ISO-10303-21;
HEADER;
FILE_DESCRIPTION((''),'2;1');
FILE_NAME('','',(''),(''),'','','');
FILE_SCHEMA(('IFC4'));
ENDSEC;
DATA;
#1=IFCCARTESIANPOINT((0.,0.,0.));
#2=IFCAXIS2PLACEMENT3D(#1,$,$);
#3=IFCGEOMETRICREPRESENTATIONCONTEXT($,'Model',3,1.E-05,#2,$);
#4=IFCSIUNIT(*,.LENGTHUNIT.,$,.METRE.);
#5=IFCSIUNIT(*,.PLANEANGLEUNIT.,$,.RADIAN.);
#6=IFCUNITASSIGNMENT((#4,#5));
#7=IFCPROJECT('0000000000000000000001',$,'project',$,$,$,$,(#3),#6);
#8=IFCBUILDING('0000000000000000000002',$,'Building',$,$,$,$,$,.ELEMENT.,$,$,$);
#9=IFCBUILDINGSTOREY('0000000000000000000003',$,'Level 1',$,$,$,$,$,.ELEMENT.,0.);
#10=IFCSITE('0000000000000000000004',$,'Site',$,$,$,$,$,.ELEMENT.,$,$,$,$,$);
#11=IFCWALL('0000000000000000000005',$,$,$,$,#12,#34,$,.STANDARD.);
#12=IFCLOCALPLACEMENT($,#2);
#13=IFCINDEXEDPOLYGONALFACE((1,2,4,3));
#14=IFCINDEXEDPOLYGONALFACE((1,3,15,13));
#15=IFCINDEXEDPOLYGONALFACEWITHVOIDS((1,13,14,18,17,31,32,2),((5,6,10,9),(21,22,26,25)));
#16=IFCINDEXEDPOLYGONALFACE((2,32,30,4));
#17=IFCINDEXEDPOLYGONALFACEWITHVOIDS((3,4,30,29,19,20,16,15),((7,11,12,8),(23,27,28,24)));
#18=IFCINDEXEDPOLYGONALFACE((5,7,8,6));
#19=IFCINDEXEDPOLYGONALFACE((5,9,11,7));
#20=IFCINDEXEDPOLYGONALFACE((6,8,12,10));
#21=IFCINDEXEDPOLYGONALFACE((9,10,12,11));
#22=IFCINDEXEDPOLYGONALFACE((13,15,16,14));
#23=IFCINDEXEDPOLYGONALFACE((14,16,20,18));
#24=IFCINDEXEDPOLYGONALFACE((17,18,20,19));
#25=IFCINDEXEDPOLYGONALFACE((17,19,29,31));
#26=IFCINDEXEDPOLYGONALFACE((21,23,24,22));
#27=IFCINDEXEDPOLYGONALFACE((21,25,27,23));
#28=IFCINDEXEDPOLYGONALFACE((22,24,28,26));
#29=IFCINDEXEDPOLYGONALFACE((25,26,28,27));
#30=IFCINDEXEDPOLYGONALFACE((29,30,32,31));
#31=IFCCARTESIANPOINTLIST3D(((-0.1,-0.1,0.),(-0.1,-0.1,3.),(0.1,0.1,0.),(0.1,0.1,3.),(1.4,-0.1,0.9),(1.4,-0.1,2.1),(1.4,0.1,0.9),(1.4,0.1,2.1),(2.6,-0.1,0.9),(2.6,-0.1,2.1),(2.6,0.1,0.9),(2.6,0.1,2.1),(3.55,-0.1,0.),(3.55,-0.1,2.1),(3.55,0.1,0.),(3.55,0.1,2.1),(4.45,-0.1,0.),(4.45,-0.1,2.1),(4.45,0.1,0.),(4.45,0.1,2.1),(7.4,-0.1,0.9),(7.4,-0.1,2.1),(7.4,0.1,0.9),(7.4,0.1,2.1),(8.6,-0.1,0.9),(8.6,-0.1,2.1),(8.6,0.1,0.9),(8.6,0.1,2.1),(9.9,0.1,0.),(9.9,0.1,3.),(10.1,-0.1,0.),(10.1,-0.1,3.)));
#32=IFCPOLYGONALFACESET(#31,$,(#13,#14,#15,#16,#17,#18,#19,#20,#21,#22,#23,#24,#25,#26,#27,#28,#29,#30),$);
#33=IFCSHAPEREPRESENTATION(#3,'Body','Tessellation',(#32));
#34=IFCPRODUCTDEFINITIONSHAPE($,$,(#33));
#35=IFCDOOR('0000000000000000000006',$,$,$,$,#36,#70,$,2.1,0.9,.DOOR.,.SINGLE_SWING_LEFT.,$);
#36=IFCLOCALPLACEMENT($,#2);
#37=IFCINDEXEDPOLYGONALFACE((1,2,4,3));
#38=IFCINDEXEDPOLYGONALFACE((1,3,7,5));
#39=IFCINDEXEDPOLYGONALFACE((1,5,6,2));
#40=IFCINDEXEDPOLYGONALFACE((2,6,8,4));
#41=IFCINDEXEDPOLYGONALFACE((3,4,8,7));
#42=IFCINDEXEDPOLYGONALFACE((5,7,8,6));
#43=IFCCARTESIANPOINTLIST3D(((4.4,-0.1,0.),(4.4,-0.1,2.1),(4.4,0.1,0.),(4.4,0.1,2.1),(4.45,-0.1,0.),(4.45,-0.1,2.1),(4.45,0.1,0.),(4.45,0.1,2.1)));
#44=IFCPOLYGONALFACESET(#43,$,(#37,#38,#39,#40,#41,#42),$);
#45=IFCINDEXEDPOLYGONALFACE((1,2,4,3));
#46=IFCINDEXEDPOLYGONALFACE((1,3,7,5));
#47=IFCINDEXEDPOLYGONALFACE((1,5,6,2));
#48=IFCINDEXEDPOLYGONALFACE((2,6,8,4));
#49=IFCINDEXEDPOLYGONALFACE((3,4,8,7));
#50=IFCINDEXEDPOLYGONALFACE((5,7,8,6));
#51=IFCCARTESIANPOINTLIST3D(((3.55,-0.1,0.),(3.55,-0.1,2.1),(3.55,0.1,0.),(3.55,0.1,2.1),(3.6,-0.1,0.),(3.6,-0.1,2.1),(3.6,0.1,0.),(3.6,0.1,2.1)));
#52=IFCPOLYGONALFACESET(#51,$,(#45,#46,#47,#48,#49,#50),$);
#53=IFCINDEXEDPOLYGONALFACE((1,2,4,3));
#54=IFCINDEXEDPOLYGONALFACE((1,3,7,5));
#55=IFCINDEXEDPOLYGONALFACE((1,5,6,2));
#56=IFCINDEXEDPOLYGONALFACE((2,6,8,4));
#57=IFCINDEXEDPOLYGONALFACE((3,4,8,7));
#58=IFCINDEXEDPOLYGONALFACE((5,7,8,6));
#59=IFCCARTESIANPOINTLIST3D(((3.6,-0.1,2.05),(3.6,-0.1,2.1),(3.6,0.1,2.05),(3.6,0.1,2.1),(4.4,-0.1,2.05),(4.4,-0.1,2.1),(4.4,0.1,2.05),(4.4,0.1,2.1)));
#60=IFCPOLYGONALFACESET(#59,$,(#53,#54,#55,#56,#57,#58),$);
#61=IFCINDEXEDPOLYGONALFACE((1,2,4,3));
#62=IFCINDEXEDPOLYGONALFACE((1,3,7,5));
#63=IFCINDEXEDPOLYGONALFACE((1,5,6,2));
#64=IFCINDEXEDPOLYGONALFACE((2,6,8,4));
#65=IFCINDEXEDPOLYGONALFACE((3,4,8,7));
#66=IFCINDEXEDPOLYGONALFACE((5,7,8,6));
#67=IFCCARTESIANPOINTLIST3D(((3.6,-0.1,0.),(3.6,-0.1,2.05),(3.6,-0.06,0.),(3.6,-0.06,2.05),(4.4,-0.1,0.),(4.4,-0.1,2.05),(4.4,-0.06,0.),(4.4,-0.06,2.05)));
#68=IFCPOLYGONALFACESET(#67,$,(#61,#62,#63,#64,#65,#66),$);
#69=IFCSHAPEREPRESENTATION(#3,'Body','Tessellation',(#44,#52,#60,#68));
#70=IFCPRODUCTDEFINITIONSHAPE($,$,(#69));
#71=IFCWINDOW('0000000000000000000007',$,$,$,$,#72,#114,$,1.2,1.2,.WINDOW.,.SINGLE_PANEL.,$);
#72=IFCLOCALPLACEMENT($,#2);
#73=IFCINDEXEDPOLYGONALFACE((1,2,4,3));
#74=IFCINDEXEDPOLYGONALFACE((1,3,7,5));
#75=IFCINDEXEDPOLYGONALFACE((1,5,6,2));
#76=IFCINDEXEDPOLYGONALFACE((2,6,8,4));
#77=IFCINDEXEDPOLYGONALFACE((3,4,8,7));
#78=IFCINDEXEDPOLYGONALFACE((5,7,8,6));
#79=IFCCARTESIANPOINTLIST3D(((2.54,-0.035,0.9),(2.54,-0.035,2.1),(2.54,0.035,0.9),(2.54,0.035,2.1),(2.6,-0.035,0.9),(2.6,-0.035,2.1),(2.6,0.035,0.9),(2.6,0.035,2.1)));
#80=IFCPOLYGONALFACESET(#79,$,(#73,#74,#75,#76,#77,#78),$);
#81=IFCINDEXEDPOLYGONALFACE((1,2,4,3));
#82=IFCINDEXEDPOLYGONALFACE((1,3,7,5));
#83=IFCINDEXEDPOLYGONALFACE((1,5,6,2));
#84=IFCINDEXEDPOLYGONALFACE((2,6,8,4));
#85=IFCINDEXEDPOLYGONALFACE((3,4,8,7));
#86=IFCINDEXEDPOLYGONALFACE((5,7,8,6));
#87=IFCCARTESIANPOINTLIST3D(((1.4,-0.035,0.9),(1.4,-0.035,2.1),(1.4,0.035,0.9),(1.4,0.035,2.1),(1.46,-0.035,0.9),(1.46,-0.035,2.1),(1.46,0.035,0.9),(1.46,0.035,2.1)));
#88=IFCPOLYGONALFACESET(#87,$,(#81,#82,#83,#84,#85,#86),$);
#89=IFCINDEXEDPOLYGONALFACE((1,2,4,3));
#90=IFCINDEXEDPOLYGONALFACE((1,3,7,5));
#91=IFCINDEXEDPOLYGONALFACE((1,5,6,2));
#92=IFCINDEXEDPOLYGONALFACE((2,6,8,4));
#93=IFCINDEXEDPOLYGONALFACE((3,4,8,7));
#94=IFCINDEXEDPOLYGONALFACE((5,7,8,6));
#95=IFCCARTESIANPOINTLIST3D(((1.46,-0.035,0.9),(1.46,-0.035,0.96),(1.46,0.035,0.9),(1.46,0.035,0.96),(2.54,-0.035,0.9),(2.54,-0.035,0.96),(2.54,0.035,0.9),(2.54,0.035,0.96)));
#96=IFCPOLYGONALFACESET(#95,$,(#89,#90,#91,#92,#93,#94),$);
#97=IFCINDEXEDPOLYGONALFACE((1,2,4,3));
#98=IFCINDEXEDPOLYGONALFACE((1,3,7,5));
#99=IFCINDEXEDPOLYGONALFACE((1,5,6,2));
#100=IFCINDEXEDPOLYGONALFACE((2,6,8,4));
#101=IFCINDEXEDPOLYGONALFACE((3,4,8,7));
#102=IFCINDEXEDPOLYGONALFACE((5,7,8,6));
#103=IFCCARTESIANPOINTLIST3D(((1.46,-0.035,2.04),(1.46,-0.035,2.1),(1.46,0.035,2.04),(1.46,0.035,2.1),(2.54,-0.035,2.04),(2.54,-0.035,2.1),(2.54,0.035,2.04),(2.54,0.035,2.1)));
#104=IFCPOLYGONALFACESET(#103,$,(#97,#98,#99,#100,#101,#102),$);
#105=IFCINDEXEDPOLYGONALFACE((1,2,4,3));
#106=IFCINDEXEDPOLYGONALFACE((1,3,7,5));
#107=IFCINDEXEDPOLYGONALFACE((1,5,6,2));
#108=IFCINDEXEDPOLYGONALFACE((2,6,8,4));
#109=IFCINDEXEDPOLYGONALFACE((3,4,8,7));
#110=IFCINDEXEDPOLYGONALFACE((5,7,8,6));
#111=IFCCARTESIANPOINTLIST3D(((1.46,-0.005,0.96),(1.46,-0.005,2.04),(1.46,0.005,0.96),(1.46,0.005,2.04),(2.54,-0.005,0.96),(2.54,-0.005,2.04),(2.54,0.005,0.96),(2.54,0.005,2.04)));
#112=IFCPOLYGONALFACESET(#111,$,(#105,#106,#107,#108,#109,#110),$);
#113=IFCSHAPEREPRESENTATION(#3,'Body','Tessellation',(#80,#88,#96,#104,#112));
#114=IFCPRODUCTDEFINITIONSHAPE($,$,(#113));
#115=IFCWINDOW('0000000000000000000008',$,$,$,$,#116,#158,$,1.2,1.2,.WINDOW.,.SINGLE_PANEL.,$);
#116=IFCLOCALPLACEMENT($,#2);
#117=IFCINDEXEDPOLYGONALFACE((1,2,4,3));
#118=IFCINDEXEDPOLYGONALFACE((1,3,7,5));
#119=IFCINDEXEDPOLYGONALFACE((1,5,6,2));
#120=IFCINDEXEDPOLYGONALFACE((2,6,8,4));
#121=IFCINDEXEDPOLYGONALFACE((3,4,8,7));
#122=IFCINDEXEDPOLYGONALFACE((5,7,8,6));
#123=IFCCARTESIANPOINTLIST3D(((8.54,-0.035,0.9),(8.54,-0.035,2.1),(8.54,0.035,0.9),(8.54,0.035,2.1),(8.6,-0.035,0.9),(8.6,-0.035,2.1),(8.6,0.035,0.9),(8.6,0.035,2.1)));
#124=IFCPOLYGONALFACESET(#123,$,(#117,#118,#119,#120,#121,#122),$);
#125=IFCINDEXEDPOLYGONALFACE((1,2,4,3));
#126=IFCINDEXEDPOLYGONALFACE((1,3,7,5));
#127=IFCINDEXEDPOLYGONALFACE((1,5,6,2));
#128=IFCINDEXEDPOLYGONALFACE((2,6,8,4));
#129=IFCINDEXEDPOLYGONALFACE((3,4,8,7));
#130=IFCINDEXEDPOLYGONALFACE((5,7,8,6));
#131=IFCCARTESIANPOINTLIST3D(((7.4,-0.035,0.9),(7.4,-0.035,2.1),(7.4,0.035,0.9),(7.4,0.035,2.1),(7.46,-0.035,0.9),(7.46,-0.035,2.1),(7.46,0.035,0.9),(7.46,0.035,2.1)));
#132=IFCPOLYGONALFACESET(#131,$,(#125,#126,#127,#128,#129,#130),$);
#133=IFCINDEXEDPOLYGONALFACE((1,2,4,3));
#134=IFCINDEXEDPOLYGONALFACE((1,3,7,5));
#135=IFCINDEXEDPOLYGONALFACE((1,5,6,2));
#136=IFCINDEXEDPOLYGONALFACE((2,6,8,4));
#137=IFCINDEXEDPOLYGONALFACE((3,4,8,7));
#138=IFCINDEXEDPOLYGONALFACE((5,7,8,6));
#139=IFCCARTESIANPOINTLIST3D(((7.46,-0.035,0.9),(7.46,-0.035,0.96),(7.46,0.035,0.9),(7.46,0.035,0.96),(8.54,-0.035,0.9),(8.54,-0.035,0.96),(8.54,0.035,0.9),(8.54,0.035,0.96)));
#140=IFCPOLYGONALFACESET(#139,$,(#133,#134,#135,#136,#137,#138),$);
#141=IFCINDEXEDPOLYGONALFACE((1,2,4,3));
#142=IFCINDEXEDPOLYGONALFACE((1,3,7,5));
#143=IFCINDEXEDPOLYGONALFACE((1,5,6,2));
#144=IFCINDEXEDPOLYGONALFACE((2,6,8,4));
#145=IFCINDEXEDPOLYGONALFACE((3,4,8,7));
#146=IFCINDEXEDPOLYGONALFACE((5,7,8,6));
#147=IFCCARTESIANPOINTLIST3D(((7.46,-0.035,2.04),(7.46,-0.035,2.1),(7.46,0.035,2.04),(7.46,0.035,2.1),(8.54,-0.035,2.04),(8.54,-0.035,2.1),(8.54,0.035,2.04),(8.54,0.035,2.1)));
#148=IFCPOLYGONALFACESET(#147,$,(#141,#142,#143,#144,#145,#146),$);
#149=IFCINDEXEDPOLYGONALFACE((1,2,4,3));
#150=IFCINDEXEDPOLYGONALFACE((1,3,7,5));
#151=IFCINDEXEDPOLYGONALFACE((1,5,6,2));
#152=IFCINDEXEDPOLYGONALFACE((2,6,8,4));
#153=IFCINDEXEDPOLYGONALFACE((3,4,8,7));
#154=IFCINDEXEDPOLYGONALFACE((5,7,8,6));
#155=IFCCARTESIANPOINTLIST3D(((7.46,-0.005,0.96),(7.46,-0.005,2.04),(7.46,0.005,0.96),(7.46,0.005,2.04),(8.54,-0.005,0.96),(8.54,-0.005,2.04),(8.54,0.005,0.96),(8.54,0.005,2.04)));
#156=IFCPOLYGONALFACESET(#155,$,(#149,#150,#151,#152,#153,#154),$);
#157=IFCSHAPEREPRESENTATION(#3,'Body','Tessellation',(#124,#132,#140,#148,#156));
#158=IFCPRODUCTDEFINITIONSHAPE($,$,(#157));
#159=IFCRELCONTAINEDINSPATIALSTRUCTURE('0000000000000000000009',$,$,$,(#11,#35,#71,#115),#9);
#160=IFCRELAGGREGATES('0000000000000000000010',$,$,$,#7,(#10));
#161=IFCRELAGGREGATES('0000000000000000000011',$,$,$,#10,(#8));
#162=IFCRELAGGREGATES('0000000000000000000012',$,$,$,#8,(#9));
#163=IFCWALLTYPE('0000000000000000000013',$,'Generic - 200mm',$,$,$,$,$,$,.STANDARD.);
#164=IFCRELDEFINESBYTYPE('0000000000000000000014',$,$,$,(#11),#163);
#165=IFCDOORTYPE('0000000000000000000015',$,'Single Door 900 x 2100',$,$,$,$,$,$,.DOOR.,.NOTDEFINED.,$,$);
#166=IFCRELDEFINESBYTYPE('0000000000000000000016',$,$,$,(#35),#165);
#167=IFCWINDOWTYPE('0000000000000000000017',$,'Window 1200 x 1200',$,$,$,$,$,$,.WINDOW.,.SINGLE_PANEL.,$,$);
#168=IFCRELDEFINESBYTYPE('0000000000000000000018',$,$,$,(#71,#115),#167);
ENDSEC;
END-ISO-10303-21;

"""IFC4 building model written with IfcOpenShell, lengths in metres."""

from ifc_helpers import new_model, si_unit, frame, frame_2d, origin, origin_with_axes, origin_2d, place, context, project, spatial, polyline, rectangle, outline, extrude, type_object, element, fill, save


model = new_model("IFC4")

# Units and contexts
model_context = context("Model", 3, precision=1e-05, world=origin())
ifc_project = project(units=[si_unit("LENGTHUNIT", "METRE"), si_unit("PLANEANGLEUNIT", "RADIAN")], contexts=[model_context])

# Site, building, storey
site = spatial("IfcSite", under=ifc_project, Name="Site", CompositionType="ELEMENT")
building = spatial("IfcBuilding", under=site, Name="Building", CompositionType="ELEMENT")
storey = spatial("IfcBuildingStorey", under=building, Name="Level 1", CompositionType="ELEMENT", Elevation=0.0)

# Wall, openings, door, windows
wall_type = type_object("IfcWallType", Name="Generic - 200mm", PredefinedType="STANDARD")
wall_1_placement = place(None, frame((10.0, 0.0, 0.0), z_axis=(0.0, 0.0, 1.0), x_axis=(-1.0, 0.0, 0.0)))
wall_1 = element("IfcWall", 1, at=wall_1_placement, inside=storey, type_object=wall_type, PredefinedType="STANDARD", context=model_context, shape_type="SweptSolid", body=[
    extrude(outline(polyline([(0.1, -0.1), (9.9, -0.1), (10.1, 0.1), (-0.1, 0.1), (0.1, -0.1)])), origin(), (0.0, 0.0, 1.0), 3.0),
])
opening_1_placement = place(wall_1_placement, frame((6.0, 0.0, 0.0), z_axis=(0.0, 0.0, 1.0), x_axis=(1.0, 0.0, 0.0)))
opening_1 = element("IfcOpeningElement", 2, at=opening_1_placement, cuts=wall_1, PredefinedType="OPENING", context=model_context, shape_type="SweptSolid", body=[
    extrude(rectangle(XDim=0.9, YDim=0.202, at=origin_2d()), origin(), (0.0, 0.0, 1.0), 2.1),
])
opening_2_placement = place(wall_1_placement, frame((8.0, 0.0, 0.9), z_axis=(0.0, 0.0, 1.0), x_axis=(1.0, 0.0, 0.0)))
opening_2 = element("IfcOpeningElement", 3, at=opening_2_placement, cuts=wall_1, PredefinedType="OPENING", context=model_context, shape_type="SweptSolid", body=[
    extrude(rectangle(XDim=1.2, YDim=0.202, at=origin_2d()), origin(), (0.0, 0.0, 1.0), 1.2),
])
opening_3_placement = place(wall_1_placement, frame((2.0, 0.0, 0.9), z_axis=(0.0, 0.0, 1.0), x_axis=(1.0, 0.0, 0.0)))
opening_3 = element("IfcOpeningElement", 4, at=opening_3_placement, cuts=wall_1, PredefinedType="OPENING", context=model_context, shape_type="SweptSolid", body=[
    extrude(rectangle(XDim=1.2, YDim=0.202, at=origin_2d()), origin(), (0.0, 0.0, 1.0), 1.2),
])
door_type = type_object("IfcDoorType", Name="Single Door 900 x 2100", OperationType="NOTDEFINED", PredefinedType="DOOR")
door_1_placement = place(opening_1_placement, origin_with_axes())
door_1 = element("IfcDoor", 5, at=door_1_placement, inside=storey, type_object=door_type, OperationType="SINGLE_SWING_LEFT", OverallHeight=2.1, OverallWidth=0.9, PredefinedType="DOOR", context=model_context, shape_type="SweptSolid", body=[
    extrude(rectangle(XDim=0.05, YDim=0.2, at=frame_2d((-0.425, 0.0))), origin(), (0.0, 0.0, 1.0), 2.1),
    extrude(rectangle(XDim=0.05, YDim=0.2, at=frame_2d((0.425, 0.0))), origin(), (0.0, 0.0, 1.0), 2.1),
    extrude(rectangle(XDim=0.8, YDim=0.2, at=origin_2d()), frame((0.0, 0.0, 2.05)), (0.0, 0.0, 1.0), 0.05),
    extrude(rectangle(XDim=0.8, YDim=0.04, at=frame_2d((0.0, 0.08))), origin(), (0.0, 0.0, 1.0), 2.05),
])
fill(opening_1, door_1)
window_type = type_object("IfcWindowType", Name="Window 1200 x 1200", PartitioningType="SINGLE_PANEL", PredefinedType="WINDOW")
window_1_placement = place(opening_2_placement, origin_with_axes())
window_1 = element("IfcWindow", 6, at=window_1_placement, inside=storey, type_object=window_type, OverallHeight=1.2, OverallWidth=1.2, PartitioningType="SINGLE_PANEL", PredefinedType="WINDOW", context=model_context, shape_type="SweptSolid", body=[
    extrude(rectangle(XDim=0.06, YDim=0.07, at=frame_2d((-0.57, 0.0))), origin(), (0.0, 0.0, 1.0), 1.2),
    extrude(rectangle(XDim=0.06, YDim=0.07, at=frame_2d((0.57, 0.0))), origin(), (0.0, 0.0, 1.0), 1.2),
    extrude(rectangle(XDim=1.08, YDim=0.07, at=origin_2d()), origin(), (0.0, 0.0, 1.0), 0.06),
    extrude(rectangle(XDim=1.08, YDim=0.07, at=origin_2d()), frame((0.0, 0.0, 1.14)), (0.0, 0.0, 1.0), 0.06),
    extrude(rectangle(XDim=1.08, YDim=0.01, at=origin_2d()), frame((0.0, 0.0, 0.06)), (0.0, 0.0, 1.0), 1.08),
])
fill(opening_2, window_1)
window_2_placement = place(opening_3_placement, origin_with_axes())
window_2 = element("IfcWindow", 7, at=window_2_placement, inside=storey, type_object=window_type, OverallHeight=1.2, OverallWidth=1.2, PartitioningType="SINGLE_PANEL", PredefinedType="WINDOW", context=model_context, shape_type="SweptSolid", body=[
    extrude(rectangle(XDim=0.06, YDim=0.07, at=frame_2d((-0.57, 0.0))), origin(), (0.0, 0.0, 1.0), 1.2),
    extrude(rectangle(XDim=0.06, YDim=0.07, at=frame_2d((0.57, 0.0))), origin(), (0.0, 0.0, 1.0), 1.2),
    extrude(rectangle(XDim=1.08, YDim=0.07, at=origin_2d()), origin(), (0.0, 0.0, 1.0), 0.06),
    extrude(rectangle(XDim=1.08, YDim=0.07, at=origin_2d()), frame((0.0, 0.0, 1.14)), (0.0, 0.0, 1.0), 0.06),
    extrude(rectangle(XDim=1.08, YDim=0.01, at=origin_2d()), frame((0.0, 0.0, 0.06)), (0.0, 0.0, 1.0), 1.08),
])
fill(opening_3, window_2)

save(model, "model.ifc")
